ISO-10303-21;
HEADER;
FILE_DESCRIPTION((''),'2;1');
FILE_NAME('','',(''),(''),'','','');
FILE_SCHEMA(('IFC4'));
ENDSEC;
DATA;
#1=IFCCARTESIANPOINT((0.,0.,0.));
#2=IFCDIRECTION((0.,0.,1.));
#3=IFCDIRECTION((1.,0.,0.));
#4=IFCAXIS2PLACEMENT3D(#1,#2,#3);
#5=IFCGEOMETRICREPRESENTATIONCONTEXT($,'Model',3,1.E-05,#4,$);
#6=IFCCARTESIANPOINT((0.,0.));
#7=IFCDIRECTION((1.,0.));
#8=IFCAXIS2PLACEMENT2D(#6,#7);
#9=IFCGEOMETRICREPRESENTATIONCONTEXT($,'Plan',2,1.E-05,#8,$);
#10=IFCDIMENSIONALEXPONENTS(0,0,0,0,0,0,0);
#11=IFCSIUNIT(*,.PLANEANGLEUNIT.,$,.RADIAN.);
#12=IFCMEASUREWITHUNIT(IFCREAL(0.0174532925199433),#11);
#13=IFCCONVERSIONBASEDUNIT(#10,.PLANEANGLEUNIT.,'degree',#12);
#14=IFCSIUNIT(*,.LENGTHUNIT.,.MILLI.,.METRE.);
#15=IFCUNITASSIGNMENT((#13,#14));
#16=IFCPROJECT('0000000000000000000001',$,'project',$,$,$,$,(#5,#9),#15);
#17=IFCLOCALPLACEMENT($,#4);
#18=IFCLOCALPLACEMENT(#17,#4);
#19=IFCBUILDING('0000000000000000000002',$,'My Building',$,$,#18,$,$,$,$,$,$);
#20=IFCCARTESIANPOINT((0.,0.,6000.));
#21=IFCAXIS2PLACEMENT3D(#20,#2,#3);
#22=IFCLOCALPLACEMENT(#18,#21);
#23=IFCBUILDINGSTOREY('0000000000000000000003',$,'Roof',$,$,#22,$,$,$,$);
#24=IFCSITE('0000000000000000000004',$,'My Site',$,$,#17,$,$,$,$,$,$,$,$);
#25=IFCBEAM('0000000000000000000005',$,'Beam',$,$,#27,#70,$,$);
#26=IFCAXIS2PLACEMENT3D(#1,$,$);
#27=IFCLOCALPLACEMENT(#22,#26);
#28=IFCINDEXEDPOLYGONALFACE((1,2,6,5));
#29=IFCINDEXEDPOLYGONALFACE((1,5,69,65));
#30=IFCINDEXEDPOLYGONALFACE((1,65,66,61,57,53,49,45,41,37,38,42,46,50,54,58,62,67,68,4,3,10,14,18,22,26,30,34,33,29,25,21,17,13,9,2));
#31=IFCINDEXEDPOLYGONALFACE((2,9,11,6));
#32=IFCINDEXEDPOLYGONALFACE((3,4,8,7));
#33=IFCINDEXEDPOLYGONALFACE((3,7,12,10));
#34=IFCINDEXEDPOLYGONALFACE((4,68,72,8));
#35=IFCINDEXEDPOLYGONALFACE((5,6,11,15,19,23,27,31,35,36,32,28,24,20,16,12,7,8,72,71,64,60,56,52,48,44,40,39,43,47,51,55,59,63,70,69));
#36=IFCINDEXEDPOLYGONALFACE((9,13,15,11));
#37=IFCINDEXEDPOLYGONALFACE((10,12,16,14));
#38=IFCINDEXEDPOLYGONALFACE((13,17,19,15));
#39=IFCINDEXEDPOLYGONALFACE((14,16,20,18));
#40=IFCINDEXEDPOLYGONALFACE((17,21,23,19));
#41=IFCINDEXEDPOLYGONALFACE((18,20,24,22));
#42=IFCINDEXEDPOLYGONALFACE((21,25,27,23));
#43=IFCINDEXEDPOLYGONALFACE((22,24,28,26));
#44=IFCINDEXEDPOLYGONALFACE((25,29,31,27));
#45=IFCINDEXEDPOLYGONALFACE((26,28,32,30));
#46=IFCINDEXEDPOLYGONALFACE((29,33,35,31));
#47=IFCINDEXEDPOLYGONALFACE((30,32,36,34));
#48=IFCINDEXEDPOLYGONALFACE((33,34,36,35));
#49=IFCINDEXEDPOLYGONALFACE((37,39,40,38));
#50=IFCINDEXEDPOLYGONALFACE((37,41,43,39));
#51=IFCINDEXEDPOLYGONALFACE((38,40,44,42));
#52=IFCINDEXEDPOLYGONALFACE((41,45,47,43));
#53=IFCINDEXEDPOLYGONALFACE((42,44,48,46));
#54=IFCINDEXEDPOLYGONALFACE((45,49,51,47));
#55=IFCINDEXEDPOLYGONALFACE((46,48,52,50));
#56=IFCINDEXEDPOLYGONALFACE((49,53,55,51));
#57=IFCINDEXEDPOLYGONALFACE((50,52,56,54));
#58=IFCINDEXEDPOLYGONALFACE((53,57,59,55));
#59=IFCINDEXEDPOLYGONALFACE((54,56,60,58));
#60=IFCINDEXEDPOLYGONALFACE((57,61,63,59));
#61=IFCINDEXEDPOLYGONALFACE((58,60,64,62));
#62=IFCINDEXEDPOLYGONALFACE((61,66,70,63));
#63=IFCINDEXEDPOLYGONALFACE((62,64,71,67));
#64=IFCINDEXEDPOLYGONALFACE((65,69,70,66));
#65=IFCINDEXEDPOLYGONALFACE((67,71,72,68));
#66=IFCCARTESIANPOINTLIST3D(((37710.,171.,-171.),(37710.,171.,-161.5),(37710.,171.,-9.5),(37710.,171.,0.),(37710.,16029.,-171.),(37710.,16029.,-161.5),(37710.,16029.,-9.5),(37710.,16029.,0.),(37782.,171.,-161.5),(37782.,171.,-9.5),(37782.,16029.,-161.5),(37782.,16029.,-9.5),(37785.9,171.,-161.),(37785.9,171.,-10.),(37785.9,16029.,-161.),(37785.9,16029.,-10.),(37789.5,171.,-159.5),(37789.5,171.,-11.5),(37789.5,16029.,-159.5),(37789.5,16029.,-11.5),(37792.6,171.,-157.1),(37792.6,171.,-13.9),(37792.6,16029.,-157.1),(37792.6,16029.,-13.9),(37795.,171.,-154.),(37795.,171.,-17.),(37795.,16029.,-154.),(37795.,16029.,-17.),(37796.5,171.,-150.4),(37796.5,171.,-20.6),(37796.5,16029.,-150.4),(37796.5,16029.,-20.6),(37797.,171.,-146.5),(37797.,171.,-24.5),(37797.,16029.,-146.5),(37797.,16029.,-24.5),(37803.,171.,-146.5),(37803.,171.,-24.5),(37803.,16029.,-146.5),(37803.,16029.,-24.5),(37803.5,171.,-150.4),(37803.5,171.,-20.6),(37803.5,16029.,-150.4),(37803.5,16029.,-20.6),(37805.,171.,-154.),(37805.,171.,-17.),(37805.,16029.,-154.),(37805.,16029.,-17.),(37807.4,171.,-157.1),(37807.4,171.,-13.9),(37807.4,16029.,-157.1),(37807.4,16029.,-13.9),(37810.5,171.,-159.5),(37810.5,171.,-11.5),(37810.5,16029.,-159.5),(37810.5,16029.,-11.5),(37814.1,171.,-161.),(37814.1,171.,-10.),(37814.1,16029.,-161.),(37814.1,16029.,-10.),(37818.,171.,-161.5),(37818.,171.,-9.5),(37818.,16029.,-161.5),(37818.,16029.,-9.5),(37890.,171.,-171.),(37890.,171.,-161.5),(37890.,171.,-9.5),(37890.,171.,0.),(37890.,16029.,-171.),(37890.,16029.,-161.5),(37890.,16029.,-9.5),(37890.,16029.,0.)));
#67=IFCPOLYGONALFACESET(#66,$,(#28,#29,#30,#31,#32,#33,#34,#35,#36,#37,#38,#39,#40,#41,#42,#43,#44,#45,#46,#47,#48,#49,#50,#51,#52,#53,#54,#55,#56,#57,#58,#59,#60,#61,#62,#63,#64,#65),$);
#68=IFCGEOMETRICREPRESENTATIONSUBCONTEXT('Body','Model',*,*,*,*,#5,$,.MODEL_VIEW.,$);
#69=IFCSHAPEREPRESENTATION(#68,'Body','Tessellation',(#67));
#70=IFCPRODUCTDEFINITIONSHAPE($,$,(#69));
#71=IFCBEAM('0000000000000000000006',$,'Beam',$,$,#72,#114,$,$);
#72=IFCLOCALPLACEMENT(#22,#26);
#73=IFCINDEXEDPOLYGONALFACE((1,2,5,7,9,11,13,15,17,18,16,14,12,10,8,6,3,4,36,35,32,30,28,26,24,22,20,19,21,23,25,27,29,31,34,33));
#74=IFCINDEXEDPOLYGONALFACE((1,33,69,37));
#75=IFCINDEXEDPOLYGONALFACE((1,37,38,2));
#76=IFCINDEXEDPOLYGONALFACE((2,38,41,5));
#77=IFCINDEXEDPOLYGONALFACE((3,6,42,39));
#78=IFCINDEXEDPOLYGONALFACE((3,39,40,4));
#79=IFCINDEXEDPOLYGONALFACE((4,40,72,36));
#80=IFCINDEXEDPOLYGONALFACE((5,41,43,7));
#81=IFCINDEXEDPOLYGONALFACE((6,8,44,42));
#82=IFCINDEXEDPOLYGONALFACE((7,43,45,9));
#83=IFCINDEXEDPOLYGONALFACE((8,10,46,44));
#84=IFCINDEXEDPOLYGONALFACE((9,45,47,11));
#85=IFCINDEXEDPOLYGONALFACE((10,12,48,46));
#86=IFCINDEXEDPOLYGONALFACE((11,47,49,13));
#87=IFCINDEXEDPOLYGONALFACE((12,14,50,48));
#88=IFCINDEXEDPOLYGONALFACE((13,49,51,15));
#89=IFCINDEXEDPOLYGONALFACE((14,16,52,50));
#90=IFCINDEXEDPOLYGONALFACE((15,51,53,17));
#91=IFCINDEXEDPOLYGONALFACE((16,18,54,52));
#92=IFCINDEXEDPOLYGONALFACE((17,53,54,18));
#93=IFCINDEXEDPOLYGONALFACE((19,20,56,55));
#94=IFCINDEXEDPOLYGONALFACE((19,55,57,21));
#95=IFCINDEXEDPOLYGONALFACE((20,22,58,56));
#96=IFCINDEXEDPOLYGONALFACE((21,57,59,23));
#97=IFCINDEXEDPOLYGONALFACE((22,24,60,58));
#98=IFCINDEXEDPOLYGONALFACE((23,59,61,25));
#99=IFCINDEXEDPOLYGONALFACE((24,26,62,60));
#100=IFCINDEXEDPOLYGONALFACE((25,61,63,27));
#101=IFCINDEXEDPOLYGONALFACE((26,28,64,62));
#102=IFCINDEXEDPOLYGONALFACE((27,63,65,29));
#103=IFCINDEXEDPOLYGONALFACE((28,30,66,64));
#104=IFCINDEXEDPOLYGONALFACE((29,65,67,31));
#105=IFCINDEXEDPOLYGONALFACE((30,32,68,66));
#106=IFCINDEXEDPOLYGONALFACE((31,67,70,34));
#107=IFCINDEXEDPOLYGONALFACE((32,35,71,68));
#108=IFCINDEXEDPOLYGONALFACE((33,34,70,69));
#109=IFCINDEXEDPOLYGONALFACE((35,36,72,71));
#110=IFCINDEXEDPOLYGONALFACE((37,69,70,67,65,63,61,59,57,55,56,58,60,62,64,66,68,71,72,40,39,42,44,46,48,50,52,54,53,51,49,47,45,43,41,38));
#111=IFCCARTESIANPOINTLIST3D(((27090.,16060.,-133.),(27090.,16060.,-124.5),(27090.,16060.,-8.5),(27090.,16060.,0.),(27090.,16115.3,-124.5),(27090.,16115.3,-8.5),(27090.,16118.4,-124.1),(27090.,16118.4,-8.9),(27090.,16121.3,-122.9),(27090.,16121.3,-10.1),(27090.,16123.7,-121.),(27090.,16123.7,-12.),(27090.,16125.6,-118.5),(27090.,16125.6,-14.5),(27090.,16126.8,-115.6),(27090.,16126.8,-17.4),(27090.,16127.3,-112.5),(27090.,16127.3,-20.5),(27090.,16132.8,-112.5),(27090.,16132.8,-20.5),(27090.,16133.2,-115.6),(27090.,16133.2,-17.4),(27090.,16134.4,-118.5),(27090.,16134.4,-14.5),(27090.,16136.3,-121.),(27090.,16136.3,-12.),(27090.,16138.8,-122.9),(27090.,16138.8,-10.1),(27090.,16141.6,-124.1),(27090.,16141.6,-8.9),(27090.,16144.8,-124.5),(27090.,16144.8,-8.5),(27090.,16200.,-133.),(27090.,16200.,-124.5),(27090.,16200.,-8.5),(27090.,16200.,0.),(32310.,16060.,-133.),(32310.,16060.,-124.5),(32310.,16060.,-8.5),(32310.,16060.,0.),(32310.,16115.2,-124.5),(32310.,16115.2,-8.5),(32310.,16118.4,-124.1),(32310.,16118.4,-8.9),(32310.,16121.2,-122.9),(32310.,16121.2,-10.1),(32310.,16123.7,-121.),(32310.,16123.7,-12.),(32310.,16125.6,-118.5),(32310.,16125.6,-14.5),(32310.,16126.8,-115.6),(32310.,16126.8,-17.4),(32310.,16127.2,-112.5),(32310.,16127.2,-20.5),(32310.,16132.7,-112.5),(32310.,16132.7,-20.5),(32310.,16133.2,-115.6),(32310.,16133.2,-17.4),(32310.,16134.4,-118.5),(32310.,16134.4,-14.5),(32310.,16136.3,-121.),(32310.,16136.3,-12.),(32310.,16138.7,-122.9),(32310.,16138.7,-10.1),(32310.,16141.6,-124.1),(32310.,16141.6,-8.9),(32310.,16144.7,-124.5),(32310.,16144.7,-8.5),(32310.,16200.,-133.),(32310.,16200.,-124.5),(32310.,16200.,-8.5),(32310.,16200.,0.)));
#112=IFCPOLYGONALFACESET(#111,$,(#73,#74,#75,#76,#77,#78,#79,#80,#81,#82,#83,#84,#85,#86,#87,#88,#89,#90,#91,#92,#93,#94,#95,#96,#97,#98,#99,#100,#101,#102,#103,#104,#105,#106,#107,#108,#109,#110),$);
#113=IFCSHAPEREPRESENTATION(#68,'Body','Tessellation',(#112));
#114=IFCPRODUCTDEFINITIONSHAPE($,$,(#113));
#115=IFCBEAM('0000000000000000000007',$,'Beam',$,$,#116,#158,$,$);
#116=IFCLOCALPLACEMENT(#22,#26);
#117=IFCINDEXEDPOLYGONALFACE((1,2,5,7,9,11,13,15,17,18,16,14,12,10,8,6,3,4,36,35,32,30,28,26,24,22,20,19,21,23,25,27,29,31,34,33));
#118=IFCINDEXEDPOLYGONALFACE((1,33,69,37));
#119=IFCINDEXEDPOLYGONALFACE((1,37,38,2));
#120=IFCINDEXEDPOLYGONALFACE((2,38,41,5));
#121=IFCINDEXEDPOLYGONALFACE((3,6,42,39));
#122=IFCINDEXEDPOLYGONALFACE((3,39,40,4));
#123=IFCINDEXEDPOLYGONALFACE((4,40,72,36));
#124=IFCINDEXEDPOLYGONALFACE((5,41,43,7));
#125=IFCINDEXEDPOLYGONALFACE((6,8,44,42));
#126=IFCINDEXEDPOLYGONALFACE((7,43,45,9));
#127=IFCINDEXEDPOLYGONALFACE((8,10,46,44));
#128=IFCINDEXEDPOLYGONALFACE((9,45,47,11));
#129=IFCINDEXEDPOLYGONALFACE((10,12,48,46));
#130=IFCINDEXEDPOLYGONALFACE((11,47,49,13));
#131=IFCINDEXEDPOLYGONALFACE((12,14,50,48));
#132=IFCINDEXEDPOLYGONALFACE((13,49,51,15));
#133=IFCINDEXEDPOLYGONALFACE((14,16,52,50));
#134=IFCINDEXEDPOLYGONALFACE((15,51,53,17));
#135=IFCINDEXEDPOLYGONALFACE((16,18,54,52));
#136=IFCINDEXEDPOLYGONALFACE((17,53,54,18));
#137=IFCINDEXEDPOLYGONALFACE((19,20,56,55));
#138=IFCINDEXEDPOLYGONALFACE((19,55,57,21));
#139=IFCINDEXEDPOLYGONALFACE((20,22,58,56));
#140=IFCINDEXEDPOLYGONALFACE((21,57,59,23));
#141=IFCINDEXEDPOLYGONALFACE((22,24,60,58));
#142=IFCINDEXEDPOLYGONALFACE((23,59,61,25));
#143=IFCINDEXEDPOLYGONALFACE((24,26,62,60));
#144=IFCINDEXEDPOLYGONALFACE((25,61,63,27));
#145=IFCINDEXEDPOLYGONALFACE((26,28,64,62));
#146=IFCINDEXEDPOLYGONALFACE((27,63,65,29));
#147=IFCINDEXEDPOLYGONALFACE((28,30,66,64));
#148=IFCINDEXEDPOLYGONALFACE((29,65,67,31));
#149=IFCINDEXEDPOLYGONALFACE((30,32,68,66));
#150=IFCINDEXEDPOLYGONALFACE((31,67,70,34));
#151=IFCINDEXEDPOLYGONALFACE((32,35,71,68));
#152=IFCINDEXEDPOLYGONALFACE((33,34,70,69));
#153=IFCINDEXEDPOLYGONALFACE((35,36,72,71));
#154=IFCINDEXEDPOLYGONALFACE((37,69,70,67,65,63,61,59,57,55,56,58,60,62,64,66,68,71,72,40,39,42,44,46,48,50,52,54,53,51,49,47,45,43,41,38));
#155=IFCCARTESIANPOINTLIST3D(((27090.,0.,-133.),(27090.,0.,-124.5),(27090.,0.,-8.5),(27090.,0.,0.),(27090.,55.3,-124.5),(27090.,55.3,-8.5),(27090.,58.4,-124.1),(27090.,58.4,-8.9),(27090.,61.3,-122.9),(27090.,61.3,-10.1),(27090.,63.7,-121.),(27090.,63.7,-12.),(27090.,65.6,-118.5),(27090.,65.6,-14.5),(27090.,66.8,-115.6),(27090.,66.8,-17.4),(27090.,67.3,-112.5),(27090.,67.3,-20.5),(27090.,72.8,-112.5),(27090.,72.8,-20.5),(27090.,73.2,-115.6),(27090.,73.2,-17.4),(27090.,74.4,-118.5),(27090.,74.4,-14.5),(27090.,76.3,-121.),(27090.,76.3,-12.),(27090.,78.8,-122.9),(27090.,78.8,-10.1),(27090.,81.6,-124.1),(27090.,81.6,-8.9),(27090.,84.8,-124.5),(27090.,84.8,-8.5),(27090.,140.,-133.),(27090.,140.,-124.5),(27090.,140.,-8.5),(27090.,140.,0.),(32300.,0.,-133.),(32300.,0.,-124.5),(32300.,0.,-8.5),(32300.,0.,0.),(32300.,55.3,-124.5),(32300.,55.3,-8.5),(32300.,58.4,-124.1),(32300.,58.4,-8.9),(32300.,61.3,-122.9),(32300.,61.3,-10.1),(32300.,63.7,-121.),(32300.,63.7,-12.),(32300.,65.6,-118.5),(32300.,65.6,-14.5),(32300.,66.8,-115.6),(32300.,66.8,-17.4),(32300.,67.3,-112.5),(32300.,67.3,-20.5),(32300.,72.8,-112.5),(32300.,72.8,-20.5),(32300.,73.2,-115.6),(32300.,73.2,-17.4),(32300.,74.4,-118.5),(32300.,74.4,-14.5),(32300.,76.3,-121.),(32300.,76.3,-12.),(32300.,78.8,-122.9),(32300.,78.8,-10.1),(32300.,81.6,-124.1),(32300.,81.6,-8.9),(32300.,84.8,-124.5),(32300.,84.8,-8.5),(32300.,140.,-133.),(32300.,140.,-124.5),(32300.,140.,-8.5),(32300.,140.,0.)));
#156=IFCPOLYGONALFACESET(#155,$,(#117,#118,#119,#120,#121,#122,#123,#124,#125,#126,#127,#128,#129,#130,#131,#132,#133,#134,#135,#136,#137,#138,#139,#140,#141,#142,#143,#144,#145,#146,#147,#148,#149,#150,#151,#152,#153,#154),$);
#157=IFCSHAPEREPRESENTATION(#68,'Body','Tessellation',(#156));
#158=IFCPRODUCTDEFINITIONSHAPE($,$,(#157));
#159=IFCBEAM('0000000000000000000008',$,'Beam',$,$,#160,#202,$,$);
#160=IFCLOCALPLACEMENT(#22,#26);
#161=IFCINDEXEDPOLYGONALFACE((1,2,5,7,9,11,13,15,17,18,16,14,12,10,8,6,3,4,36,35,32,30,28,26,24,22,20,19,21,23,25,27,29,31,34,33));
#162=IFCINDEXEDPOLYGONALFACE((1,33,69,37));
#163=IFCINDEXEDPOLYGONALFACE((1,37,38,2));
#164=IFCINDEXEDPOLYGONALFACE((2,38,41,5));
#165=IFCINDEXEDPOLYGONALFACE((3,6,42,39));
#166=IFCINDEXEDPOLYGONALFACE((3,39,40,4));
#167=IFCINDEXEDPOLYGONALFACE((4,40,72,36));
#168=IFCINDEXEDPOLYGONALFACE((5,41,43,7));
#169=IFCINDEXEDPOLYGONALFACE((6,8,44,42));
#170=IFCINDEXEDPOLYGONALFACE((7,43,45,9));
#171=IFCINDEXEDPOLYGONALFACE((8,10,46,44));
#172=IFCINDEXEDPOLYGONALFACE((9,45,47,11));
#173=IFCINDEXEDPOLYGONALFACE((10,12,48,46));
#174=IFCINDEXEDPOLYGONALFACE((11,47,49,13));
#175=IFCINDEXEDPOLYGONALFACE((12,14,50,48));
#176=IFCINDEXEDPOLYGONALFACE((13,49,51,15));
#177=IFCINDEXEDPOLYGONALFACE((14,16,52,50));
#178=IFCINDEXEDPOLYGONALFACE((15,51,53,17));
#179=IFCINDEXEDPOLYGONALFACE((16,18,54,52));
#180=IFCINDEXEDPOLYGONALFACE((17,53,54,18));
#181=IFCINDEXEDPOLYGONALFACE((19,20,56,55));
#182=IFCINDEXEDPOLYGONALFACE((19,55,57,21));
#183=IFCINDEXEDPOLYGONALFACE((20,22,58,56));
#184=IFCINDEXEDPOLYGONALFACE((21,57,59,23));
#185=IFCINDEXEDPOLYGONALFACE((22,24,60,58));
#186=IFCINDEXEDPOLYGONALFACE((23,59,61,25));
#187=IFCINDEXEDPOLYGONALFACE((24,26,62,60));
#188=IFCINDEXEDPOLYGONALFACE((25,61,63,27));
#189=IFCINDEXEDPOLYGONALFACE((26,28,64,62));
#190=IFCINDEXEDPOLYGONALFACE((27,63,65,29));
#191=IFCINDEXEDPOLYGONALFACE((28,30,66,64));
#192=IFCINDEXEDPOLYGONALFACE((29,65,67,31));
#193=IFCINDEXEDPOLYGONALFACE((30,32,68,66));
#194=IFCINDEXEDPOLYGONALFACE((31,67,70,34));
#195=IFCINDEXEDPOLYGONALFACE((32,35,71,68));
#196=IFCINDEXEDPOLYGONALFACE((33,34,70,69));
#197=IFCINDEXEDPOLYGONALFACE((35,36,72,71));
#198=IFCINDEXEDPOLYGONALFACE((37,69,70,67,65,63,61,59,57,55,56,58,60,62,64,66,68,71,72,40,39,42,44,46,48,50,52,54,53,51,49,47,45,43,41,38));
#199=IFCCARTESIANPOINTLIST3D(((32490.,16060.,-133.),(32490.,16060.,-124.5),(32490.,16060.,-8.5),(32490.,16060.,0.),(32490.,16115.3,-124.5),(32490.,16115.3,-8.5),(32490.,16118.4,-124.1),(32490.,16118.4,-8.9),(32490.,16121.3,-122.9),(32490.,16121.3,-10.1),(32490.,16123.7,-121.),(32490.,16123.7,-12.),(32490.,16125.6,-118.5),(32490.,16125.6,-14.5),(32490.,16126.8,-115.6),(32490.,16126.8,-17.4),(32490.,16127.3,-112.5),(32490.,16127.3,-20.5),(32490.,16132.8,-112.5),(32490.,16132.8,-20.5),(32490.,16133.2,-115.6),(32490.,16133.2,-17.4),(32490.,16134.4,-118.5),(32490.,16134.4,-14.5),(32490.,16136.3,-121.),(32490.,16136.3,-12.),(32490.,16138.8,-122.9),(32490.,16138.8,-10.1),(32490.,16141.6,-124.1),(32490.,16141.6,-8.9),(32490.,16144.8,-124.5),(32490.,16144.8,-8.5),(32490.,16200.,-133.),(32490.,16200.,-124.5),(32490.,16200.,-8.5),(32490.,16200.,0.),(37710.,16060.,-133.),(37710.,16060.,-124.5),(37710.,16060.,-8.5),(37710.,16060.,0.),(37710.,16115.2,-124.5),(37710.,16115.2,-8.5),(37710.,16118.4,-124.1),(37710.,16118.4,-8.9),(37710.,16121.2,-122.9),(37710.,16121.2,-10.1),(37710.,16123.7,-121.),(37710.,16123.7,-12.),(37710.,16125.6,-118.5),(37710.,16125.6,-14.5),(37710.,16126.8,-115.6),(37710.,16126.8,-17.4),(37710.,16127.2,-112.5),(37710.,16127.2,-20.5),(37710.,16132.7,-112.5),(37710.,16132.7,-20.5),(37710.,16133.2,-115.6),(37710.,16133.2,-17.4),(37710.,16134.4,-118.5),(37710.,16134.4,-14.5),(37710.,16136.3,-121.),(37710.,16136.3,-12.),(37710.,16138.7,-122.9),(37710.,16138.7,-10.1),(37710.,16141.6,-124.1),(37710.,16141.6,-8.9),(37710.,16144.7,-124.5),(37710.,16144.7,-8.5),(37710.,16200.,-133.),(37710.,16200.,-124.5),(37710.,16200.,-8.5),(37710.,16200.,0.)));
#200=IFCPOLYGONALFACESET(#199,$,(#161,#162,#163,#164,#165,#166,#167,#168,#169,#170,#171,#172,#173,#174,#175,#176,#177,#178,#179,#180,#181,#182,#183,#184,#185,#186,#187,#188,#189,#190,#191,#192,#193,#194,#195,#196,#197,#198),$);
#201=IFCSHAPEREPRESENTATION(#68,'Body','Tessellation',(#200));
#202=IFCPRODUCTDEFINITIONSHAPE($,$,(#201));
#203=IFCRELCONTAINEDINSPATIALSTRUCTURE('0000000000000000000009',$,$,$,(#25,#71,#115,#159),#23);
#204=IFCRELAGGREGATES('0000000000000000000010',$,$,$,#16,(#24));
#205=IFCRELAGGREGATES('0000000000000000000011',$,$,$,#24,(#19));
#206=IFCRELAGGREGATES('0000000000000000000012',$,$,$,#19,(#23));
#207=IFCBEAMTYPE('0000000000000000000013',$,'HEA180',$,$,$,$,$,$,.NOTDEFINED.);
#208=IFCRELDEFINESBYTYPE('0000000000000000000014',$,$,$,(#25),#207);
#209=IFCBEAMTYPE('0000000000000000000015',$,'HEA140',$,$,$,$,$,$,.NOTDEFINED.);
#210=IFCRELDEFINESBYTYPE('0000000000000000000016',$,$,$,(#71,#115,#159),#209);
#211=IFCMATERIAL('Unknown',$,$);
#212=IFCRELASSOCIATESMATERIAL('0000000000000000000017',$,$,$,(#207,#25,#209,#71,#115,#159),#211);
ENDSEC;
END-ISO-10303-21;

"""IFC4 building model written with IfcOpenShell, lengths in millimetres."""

from ifc_helpers import new_model, entity, si_unit, converted_unit, frame, origin_with_axes, origin_2d_with_axis, place, context, subcontext, project, spatial, i_section, extrude, material, material_profile, profile_set, profile_usage, type_object, element, save


model = new_model("IFC4")

# Units and contexts
model_context = context("Model", 3, precision=1e-05, world=origin_with_axes())
plan_context = context("Plan", 2, precision=1e-05, world=origin_2d_with_axis())
body_context = subcontext(model_context, "Body", "Model", "MODEL_VIEW")
ifc_project = project(units=[converted_unit("PLANEANGLEUNIT", "degree", entity("IfcReal", 0.0174532925199433), si_unit("PLANEANGLEUNIT", "RADIAN"), dimensions=[0, 0, 0, 0, 0, 0, 0]), si_unit("LENGTHUNIT", "METRE", prefix="MILLI")], contexts=[model_context, plan_context])

# Site, building, storey
site_placement = place(None, origin_with_axes())
site = spatial("IfcSite", under=ifc_project, at=site_placement, Name="My Site")
building_placement = place(site_placement, origin_with_axes())
building = spatial("IfcBuilding", under=site, at=building_placement, Name="My Building")
storey_placement = place(building_placement, frame((0.0, 0.0, 6000.0), z_axis=(0.0, 0.0, 1.0), x_axis=(1.0, 0.0, 0.0)))
storey = spatial("IfcBuildingStorey", under=building, at=storey_placement, Name="Roof")

# Beams
ifc_material = material(Name="Unknown")
ifc_material_profile_1 = material_profile(ifc_material, i_section(OverallWidth=180.0, OverallDepth=171.0, WebThickness=6.0, FlangeThickness=9.5, FilletRadius=15.0))
ifc_profile_set_1 = profile_set([ifc_material_profile_1])
ifc_profile_usage_1 = profile_usage(ifc_profile_set_1, cardinal=8)
beam_type_1 = type_object("IfcBeamType", Name="HEA180", PredefinedType="NOTDEFINED", material=ifc_profile_set_1)
beam_1_placement = place(storey_placement, frame((37800.0, 171.0, 0.0), z_axis=(0.000001, 1.0, 0.0), x_axis=(-1.0, 0.000001, 0.0)))
element("IfcBeam", 1, at=beam_1_placement, inside=storey, type_object=beam_type_1, material=ifc_profile_usage_1, Name="Beam", context=body_context, shape_type="SweptSolid", body=[
    extrude(i_section(OverallWidth=180.0, OverallDepth=171.0, WebThickness=6.0, FlangeThickness=9.5, FilletRadius=15.0), frame((0.0, -85.5, 0.0), z_axis=(0.0, 0.0, 1.0), x_axis=(1.0, 0.0, 0.0)), (0.0, 0.0, 1.0), 15858.0),
])
ifc_material_profile_2 = material_profile(ifc_material, i_section(OverallWidth=140.0, OverallDepth=133.0, WebThickness=5.5, FlangeThickness=8.5, FilletRadius=12.0))
ifc_profile_set_2 = profile_set([ifc_material_profile_2])
ifc_profile_usage_2 = profile_usage(ifc_profile_set_2, cardinal=7)
beam_type_2 = type_object("IfcBeamType", Name="HEA140", PredefinedType="NOTDEFINED", material=ifc_profile_set_2)
beam_2_placement = place(storey_placement, frame((27090.0, 16200.0, 0.0), z_axis=(1.0, 0.0, 0.0), x_axis=(0.0, 1.0, 0.0)))
element("IfcBeam", 2, at=beam_2_placement, inside=storey, type_object=beam_type_2, material=ifc_profile_usage_2, Name="Beam", context=body_context, shape_type="SweptSolid", body=[
    extrude(i_section(OverallWidth=140.0, OverallDepth=133.0, WebThickness=5.5, FlangeThickness=8.5, FilletRadius=12.0), frame((-70.0, -66.5, 0.0), z_axis=(0.0, 0.0, 1.0), x_axis=(1.0, 0.0, 0.0)), (0.0, 0.0, 1.0), 5220.0),
])
ifc_profile_usage_3 = profile_usage(ifc_profile_set_2, cardinal=7)
beam_3_placement = place(storey_placement, frame((32300.0, 0.0, 0.0), z_axis=(-1.0, 0.0, 0.0), x_axis=(0.0, -1.0, 0.0)))
element("IfcBeam", 3, at=beam_3_placement, inside=storey, type_object=beam_type_2, material=ifc_profile_usage_3, Name="Beam", context=body_context, shape_type="SweptSolid", body=[
    extrude(i_section(OverallWidth=140.0, OverallDepth=133.0, WebThickness=5.5, FlangeThickness=8.5, FilletRadius=12.0), frame((-70.0, -66.5, 0.0), z_axis=(0.0, 0.0, 1.0), x_axis=(1.0, 0.0, 0.0)), (0.0, 0.0, 1.0), 5210.0),
])
ifc_profile_usage_4 = profile_usage(ifc_profile_set_2, cardinal=7)
beam_4_placement = place(storey_placement, frame((32490.0, 16200.0, 0.0), z_axis=(1.0, 0.0, 0.0), x_axis=(0.0, 1.0, 0.0)))
element("IfcBeam", 4, at=beam_4_placement, inside=storey, type_object=beam_type_2, material=ifc_profile_usage_4, Name="Beam", context=body_context, shape_type="SweptSolid", body=[
    extrude(i_section(OverallWidth=140.0, OverallDepth=133.0, WebThickness=5.5, FlangeThickness=8.5, FilletRadius=12.0), frame((-70.0, -66.5, 0.0), z_axis=(0.0, 0.0, 1.0), x_axis=(1.0, 0.0, 0.0)), (0.0, 0.0, 1.0), 5220.0),
])

save(model, "model.ifc")
